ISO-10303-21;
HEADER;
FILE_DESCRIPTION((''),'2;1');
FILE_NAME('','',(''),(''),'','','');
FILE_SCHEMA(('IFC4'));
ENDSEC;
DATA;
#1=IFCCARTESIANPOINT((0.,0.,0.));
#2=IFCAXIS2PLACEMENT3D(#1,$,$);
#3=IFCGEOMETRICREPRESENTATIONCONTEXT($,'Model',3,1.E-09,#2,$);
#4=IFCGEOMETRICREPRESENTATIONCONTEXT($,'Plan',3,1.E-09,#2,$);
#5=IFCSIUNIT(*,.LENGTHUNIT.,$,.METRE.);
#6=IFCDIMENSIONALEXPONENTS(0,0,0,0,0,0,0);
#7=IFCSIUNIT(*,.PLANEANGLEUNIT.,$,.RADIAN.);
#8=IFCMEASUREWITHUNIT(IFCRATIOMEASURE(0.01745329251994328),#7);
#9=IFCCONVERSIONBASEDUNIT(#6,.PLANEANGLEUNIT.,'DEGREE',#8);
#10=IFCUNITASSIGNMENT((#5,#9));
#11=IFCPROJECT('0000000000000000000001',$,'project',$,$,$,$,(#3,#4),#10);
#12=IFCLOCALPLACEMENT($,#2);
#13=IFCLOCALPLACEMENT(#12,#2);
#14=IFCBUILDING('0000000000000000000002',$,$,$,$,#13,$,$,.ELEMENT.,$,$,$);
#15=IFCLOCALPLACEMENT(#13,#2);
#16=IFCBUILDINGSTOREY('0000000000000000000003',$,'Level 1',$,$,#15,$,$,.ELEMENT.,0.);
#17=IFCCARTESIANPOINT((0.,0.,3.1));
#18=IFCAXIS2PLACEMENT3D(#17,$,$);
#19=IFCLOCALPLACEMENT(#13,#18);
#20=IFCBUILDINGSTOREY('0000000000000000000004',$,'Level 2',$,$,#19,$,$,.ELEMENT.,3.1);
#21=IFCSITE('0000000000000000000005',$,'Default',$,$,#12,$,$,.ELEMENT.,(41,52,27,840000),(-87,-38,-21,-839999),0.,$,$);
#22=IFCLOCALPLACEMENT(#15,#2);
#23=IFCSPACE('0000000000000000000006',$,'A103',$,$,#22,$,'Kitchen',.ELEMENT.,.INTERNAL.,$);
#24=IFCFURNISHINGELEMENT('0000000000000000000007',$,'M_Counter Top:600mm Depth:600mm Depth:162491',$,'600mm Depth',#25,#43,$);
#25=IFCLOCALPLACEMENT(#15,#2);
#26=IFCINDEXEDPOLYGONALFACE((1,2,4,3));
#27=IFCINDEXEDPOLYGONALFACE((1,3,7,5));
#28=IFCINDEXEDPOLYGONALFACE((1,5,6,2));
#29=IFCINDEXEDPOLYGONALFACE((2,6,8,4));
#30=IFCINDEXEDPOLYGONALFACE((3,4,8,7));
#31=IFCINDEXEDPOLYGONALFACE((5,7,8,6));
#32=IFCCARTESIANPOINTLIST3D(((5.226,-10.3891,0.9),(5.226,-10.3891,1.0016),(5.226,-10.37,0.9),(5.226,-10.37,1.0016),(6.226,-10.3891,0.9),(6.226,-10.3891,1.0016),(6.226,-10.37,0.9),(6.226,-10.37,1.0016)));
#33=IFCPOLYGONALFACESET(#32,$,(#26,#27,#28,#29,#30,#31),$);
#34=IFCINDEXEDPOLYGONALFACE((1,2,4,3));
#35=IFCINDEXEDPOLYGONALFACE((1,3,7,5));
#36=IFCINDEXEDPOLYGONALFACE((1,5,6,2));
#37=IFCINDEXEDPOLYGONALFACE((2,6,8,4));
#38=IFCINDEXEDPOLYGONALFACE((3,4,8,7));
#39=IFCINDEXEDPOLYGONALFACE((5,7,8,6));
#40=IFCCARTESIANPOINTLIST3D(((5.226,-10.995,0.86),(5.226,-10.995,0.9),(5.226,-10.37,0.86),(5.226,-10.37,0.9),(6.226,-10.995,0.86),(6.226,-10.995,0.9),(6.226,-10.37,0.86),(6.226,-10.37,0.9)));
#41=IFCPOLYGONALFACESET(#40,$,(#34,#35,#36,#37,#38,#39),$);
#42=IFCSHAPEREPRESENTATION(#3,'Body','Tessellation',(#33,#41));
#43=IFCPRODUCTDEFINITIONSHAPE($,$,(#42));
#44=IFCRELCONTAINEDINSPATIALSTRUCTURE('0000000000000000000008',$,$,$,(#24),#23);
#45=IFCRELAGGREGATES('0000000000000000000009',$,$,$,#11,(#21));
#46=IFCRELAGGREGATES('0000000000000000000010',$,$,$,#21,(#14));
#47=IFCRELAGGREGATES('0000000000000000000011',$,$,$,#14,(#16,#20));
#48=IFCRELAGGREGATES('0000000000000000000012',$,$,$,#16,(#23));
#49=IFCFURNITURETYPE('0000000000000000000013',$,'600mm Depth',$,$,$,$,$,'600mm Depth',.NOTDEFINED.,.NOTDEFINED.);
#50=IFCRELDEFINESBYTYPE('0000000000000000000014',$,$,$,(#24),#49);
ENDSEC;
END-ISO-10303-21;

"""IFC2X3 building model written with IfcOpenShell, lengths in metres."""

from ifc_helpers import new_model, entity, si_unit, converted_unit, frame, origin, origin_2d_with_axis, place, context, project, spatial, rectangle, extrude, source, transform, mapped, type_object, type_shapes, element, save


model = new_model("IFC2X3")

# Units and contexts
model_context = context("Model", 3, precision=1e-09, world=origin())
plan_context = context("Plan", 3, precision=1e-09, world=origin())
ifc_project = project(units=[si_unit("LENGTHUNIT", "METRE"), converted_unit("PLANEANGLEUNIT", "DEGREE", entity("IfcRatioMeasure", 0.01745329251994328), si_unit("PLANEANGLEUNIT", "RADIAN"), dimensions=[0, 0, 0, 0, 0, 0, 0])], contexts=[model_context, plan_context])

# Site, building, storey
site_placement = place(None, origin())
site = spatial("IfcSite", under=ifc_project, at=site_placement, Name="Default", CompositionType="ELEMENT", RefLatitude=(41, 52, 27, 840000), RefLongitude=(-87, -38, -21, -839999), RefElevation=0.0)
building_placement = place(site_placement, origin())
building = spatial("IfcBuilding", under=site, at=building_placement, CompositionType="ELEMENT")
storey_1_placement = place(building_placement, origin())
storey_1 = spatial("IfcBuildingStorey", under=building, at=storey_1_placement, Name="Level 1", CompositionType="ELEMENT", Elevation=0.0)

# Shared definitions
storey_2_placement = place(building_placement, frame((0.0, 0.0, 3.1)))
storey_2 = spatial("IfcBuildingStorey", under=building, at=storey_2_placement, Name="Level 2", CompositionType="ELEMENT", Elevation=3.1)

# Shared definitions
space_1_placement = place(storey_1_placement, origin())
space_1 = spatial("IfcSpace", under=storey_1, at=space_1_placement, Name="A103", LongName="Kitchen", CompositionType="ELEMENT", InteriorOrExteriorSpace="INTERNAL")

# Furnishing element
furniture_type_1 = type_object("IfcFurnitureType", Name="600mm Depth", ElementType="600mm Depth", AssemblyPlace="NOTDEFINED")
shared_shape_1 = source(origin(), model_context, "Body", "SweptSolid", [
    extrude(rectangle(XDim=0.0191, YDim=1.0, at=origin_2d_with_axis()), frame((-0.7005, -0.0095, 0.9), z_axis=(0.0, 0.0, 1.0), x_axis=(0.0, -1.0, 0.0)), (0.0, 0.0, 1.0), 0.1016),
    extrude(rectangle(XDim=1.0, YDim=0.625, at=origin_2d_with_axis()), frame((-0.7005, -0.3125, 0.86), z_axis=(0.0, 0.0, 1.0), x_axis=(-1.0, 0.0, 0.0)), (0.0, 0.0, 1.0), 0.04),
])
type_shapes(furniture_type_1, [shared_shape_1])
furnishing_1_placement = place(space_1_placement, frame((6.4265, -10.37, 0.0)))
element("IfcFurnishingElement", 1, at=furnishing_1_placement, inside=space_1, type_object=furniture_type_1, Name="M_Counter Top:600mm Depth:600mm Depth:162491", ObjectType="600mm Depth", context=model_context, shape_type="MappedRepresentation", body=[
    mapped(shared_shape_1, transform((0.0, 0.0, 0.0), scale=1.0)),
])

save(model, "model.ifc")
